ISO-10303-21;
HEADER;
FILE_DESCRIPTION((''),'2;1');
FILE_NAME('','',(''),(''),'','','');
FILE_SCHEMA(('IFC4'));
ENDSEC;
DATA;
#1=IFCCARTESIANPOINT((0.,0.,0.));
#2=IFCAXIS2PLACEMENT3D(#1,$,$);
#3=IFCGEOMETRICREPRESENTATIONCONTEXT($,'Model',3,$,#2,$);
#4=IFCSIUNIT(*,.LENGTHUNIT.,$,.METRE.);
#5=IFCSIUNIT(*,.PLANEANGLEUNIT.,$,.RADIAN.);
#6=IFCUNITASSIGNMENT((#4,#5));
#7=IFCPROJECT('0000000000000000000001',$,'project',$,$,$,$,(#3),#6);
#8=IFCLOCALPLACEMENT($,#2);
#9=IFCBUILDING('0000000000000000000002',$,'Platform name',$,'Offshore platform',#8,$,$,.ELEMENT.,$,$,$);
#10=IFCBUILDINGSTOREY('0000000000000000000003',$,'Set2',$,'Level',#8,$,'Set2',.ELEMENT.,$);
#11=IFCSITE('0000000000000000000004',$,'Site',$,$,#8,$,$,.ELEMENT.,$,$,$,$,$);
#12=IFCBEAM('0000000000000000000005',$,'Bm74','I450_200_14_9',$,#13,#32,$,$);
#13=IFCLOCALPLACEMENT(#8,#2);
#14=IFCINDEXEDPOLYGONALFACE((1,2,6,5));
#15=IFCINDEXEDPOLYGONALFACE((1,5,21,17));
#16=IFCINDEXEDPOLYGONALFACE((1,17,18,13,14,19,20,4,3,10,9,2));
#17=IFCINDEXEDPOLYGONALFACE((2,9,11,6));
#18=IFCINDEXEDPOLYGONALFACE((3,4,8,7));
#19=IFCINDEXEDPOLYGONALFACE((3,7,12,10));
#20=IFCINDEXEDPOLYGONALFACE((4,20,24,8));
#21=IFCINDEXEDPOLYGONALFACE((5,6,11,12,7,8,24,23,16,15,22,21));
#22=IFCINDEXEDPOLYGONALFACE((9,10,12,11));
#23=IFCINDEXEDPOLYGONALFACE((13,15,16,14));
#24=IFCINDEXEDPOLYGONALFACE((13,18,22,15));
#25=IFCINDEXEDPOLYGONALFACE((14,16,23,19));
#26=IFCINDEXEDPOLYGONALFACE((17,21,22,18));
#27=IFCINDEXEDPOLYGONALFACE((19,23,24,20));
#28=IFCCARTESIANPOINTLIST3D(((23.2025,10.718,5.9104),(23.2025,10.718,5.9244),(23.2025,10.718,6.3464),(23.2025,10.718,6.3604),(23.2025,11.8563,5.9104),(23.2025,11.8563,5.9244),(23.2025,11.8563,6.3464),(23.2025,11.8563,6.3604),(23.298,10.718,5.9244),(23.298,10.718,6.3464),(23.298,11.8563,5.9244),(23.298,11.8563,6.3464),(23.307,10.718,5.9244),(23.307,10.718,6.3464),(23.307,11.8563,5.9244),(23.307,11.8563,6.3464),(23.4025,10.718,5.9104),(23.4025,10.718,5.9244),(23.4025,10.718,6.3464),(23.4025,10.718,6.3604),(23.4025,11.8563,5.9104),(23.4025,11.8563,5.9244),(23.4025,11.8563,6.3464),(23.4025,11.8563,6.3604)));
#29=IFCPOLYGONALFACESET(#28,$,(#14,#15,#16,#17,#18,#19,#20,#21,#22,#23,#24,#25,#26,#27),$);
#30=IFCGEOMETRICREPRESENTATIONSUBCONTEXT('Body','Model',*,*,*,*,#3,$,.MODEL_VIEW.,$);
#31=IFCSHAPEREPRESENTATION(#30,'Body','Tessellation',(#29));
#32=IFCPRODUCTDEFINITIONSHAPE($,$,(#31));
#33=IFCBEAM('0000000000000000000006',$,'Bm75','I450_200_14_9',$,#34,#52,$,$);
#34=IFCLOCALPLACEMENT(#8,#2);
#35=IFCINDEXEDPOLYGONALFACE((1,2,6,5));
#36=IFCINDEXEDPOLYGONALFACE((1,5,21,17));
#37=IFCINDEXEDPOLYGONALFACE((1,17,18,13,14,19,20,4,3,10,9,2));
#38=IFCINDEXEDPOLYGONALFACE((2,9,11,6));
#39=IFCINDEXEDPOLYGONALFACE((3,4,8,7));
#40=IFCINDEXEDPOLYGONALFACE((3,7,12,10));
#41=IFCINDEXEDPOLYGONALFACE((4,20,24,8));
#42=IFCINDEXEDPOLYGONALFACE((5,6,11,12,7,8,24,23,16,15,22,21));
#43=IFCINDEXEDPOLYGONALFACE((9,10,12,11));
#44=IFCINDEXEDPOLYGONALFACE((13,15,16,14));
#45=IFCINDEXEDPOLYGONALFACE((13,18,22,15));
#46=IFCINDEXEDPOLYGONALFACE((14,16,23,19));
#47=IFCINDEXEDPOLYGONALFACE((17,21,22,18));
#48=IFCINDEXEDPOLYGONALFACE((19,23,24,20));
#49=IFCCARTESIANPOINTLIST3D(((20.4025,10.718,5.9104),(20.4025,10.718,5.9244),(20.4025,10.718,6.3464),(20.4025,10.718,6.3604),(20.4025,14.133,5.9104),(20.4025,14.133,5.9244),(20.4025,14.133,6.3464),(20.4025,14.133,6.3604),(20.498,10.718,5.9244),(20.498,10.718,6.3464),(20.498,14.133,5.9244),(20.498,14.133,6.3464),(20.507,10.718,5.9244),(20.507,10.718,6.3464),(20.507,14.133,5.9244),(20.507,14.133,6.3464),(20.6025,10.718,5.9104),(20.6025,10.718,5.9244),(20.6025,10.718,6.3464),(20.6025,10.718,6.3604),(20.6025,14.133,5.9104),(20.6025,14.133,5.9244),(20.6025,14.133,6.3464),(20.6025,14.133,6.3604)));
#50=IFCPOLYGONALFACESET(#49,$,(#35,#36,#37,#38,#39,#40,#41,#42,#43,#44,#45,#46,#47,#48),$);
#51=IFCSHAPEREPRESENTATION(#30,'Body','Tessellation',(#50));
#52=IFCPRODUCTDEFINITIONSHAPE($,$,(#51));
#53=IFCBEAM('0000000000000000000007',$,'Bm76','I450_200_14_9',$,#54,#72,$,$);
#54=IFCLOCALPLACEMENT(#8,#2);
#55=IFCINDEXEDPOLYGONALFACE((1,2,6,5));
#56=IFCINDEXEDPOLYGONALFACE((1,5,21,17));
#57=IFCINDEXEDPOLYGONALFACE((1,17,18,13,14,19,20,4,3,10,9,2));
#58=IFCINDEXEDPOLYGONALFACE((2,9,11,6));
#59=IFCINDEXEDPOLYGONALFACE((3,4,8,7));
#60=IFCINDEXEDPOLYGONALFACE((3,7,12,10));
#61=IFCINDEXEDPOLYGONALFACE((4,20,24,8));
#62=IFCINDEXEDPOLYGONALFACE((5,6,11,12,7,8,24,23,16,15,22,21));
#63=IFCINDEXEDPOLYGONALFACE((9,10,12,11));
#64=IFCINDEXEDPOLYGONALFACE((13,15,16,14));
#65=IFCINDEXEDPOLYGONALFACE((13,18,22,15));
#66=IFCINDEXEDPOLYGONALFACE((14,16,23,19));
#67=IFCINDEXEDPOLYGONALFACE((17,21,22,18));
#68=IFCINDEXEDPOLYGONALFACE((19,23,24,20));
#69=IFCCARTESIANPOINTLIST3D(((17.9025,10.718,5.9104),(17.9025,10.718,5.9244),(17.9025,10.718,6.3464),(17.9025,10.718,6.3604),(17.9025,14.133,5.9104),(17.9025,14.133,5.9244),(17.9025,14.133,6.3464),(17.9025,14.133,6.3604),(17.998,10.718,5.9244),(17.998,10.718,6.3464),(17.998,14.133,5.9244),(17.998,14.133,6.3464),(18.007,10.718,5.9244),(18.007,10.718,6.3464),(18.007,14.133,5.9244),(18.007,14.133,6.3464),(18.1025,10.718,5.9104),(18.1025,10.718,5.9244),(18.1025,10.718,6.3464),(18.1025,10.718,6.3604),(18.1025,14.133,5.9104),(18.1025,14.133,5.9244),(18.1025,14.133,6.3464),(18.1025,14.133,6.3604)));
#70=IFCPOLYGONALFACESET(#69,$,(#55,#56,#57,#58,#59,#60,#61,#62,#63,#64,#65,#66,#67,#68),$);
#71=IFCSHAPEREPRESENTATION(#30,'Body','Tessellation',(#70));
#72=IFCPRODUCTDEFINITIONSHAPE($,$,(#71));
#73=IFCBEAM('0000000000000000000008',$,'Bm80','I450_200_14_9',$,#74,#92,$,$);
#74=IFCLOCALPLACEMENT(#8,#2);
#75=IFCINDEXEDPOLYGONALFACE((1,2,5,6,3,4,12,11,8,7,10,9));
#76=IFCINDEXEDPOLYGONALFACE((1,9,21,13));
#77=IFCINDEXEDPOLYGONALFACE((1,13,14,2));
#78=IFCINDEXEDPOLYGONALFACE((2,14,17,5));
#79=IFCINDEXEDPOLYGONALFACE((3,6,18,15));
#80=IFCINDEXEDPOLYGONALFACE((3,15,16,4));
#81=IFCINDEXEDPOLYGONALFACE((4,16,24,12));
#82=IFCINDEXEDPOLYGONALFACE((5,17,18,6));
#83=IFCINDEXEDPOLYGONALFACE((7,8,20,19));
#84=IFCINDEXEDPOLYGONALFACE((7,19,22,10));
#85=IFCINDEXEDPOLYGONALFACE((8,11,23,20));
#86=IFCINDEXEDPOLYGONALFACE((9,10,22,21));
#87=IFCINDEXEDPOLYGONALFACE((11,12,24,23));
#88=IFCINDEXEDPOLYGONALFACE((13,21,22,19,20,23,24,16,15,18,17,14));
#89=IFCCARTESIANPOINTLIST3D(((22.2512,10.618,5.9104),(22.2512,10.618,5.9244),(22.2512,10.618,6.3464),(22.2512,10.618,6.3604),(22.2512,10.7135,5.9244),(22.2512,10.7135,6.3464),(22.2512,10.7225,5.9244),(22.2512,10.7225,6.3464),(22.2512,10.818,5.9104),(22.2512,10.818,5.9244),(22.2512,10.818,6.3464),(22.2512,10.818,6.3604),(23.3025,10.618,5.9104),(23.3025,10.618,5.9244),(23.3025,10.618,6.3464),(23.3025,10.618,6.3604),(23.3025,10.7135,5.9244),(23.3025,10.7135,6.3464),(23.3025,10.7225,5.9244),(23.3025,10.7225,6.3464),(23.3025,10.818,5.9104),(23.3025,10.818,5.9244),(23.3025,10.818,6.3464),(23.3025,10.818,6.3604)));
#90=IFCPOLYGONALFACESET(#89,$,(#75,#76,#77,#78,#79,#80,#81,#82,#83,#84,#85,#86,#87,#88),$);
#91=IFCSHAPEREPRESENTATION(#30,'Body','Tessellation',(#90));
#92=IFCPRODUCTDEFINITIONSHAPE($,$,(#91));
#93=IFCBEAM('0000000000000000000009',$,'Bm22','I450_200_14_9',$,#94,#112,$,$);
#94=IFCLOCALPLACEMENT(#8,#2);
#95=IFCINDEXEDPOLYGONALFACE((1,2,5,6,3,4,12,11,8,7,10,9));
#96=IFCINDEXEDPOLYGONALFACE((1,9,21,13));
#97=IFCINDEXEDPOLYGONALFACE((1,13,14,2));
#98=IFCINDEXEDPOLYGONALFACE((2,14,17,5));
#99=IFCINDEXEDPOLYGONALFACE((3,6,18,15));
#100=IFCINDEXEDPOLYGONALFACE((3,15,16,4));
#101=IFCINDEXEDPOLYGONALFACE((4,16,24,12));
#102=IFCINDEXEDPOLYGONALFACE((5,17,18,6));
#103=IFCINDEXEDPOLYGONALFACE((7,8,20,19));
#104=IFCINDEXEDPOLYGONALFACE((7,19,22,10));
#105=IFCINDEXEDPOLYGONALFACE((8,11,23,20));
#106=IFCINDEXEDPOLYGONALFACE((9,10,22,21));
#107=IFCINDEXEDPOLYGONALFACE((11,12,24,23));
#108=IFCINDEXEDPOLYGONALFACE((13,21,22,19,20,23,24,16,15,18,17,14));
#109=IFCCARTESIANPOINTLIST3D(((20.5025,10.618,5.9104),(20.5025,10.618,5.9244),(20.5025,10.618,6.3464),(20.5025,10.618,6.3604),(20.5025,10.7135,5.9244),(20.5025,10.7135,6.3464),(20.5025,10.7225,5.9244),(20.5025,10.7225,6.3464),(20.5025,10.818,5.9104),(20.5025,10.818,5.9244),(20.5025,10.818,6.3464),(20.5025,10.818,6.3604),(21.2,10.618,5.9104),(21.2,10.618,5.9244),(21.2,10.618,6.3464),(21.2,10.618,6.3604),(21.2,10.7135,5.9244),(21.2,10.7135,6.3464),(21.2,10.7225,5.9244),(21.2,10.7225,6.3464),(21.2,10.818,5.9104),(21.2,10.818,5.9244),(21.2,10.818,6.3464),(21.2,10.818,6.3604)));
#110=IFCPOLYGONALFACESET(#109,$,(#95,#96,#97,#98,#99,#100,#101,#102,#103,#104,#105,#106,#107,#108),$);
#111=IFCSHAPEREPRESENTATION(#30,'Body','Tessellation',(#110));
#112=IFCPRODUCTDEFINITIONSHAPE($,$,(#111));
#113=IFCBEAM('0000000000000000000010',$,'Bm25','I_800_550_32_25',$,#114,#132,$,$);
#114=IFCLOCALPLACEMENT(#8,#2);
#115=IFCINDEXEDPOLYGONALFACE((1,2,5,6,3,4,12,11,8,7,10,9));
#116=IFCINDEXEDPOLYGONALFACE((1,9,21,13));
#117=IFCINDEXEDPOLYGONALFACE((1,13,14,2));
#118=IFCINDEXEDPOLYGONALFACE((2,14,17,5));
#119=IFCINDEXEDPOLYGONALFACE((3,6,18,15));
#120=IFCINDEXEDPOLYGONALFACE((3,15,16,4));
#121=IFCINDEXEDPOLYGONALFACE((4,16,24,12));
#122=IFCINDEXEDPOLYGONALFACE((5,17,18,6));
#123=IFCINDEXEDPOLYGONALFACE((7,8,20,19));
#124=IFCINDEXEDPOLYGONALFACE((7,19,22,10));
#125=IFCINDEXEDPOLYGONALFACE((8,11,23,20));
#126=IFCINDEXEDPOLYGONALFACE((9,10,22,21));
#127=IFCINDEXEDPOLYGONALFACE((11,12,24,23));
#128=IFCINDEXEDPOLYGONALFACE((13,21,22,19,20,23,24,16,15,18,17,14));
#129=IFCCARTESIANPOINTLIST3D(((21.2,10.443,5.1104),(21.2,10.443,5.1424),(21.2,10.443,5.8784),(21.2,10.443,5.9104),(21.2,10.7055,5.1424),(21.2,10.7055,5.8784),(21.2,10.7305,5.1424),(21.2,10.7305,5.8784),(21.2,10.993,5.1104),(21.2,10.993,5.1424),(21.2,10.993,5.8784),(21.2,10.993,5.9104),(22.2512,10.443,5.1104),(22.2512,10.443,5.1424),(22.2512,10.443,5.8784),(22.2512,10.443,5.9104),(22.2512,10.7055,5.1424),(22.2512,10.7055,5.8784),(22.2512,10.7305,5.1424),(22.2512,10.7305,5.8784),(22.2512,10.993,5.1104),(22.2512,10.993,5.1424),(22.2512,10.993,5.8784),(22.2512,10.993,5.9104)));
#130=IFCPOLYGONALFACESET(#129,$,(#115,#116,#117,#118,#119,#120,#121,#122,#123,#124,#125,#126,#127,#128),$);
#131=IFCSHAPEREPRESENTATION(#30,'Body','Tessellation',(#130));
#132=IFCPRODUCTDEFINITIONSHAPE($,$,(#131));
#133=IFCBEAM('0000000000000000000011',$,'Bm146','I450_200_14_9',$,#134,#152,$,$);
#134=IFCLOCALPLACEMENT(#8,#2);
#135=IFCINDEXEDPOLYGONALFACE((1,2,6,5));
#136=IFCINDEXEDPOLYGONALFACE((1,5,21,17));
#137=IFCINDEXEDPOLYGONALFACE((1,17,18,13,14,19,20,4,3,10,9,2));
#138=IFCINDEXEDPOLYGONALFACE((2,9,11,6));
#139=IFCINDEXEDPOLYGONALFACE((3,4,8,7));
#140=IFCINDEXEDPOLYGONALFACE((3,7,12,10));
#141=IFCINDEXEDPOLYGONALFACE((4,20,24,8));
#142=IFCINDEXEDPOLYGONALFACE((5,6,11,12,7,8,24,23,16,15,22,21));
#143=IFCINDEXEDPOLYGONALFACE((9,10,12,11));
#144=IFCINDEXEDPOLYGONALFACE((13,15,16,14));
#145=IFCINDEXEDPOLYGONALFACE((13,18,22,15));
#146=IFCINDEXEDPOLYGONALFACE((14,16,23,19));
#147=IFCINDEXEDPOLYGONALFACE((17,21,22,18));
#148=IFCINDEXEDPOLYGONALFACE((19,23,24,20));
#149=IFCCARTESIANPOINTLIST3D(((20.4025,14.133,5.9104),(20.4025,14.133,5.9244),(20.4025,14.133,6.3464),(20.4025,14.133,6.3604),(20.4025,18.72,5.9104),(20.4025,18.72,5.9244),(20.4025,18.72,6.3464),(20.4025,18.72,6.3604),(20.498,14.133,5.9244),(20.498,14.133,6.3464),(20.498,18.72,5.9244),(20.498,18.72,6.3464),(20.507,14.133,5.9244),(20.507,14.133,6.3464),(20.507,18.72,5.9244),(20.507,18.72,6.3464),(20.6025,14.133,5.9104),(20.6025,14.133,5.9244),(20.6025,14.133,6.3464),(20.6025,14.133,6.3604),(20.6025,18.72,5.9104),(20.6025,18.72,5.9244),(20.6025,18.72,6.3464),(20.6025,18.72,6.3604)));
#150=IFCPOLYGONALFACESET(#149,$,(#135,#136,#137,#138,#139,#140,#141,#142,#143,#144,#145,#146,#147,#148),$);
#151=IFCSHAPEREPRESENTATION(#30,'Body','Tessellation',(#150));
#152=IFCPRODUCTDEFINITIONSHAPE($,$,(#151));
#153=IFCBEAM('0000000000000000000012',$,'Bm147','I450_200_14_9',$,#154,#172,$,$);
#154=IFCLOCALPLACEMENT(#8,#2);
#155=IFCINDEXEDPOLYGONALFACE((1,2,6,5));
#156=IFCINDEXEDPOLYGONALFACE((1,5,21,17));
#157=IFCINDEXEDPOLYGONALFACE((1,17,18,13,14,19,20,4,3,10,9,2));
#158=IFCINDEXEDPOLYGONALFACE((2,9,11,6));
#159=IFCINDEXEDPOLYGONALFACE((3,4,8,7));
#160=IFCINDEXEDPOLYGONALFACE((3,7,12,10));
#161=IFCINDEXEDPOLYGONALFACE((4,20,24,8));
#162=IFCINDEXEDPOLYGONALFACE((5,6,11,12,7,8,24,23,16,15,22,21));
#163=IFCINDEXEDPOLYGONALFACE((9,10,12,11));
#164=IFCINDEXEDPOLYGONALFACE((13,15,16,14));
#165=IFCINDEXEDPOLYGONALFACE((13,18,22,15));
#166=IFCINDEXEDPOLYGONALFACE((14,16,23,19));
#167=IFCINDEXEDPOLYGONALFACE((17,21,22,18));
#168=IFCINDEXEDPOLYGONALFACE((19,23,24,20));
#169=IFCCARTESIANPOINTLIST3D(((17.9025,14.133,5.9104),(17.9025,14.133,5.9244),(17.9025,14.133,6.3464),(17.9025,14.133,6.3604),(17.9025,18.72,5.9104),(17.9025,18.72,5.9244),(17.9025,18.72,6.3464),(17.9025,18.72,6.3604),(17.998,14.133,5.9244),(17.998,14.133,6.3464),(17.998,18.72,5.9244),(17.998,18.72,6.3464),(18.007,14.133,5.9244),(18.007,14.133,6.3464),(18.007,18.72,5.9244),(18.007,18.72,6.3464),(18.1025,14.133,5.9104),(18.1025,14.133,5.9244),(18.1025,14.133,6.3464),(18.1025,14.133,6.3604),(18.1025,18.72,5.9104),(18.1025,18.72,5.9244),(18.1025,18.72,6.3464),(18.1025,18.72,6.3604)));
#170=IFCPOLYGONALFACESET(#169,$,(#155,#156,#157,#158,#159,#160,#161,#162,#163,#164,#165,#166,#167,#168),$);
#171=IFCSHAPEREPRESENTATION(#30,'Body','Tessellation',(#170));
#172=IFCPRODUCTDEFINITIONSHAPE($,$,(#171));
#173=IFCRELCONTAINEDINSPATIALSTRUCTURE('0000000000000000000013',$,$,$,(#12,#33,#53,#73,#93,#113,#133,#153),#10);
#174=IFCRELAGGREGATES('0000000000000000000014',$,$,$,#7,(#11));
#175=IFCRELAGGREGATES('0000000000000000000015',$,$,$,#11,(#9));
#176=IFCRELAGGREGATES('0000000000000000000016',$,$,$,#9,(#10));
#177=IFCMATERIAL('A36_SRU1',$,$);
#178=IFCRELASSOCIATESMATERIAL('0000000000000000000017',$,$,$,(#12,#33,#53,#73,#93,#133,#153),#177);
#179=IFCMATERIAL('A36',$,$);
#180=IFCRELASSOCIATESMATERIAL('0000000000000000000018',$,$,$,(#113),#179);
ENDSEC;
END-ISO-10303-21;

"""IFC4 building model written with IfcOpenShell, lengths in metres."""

from ifc_helpers import new_model, si_unit, frame, origin, origin_2d, place, context, subcontext, project, spatial, i_section, extrude, source, transform, mapped, material, element, save


model = new_model("IFC4")

# Units and contexts
model_context = context("Model", 3, world=origin())
body_context = subcontext(model_context, "Body", "Model", "MODEL_VIEW")
ifc_project = project(units=[si_unit("LENGTHUNIT", "METRE"), si_unit("PLANEANGLEUNIT", "RADIAN")], contexts=[model_context])

# Site, building, storey
placement_1 = place(None, origin())
site = spatial("IfcSite", under=ifc_project, at=placement_1, Name="Site", CompositionType="ELEMENT")
building = spatial("IfcBuilding", under=site, at=placement_1, Name="Platform name", ObjectType="Offshore platform", CompositionType="ELEMENT")
storey = spatial("IfcBuildingStorey", under=building, at=placement_1, Name="Set2", ObjectType="Level", LongName="Set2", CompositionType="ELEMENT")

# Beams
ifc_material_1 = material(Name="A36_SRU1")
shared_shape_1 = source(origin(), body_context, "Body", "SweptSolid", [
    extrude(i_section(OverallWidth=0.2, OverallDepth=0.45, WebThickness=0.009, FlangeThickness=0.014, FilletRadius=0.0, at=origin_2d()), frame((0.0, 0.0, 0.0), z_axis=(0.0, 1.0, 0.0), x_axis=(-1.0, 0.0, 0.0)), (0.0, 0.0, 1.0), 1.1383),
])
placement_2 = place(None, origin())
placement_3 = place(placement_2, origin())
placement_4 = place(placement_3, origin())
beam_1_placement = place(placement_4, frame((23.3025, 10.718, 6.1354)))
element("IfcBeam", 1, at=beam_1_placement, inside=storey, material=ifc_material_1, Name="Bm74", Description="I450_200_14_9", context=body_context, shape_type="MappedRepresentation", body=[
    mapped(shared_shape_1, transform((0.0, 0.0, 0.0), scale=1.0)),
])
shared_shape_2 = source(origin(), body_context, "Body", "SweptSolid", [
    extrude(i_section(OverallWidth=0.2, OverallDepth=0.45, WebThickness=0.009, FlangeThickness=0.014, FilletRadius=0.0, at=origin_2d()), frame((0.0, 0.0, 0.0), z_axis=(0.0, 1.0, 0.0), x_axis=(-1.0, 0.0, 0.0)), (0.0, 0.0, 1.0), 3.415),
])
placement_5 = place(None, origin())
placement_6 = place(placement_5, origin())
placement_7 = place(placement_6, origin())
beam_2_placement = place(placement_7, frame((20.5025, 10.718, 6.1354)))
element("IfcBeam", 2, at=beam_2_placement, inside=storey, material=ifc_material_1, Name="Bm75", Description="I450_200_14_9", context=body_context, shape_type="MappedRepresentation", body=[
    mapped(shared_shape_2, transform((0.0, 0.0, 0.0), scale=1.0)),
])
shared_shape_3 = source(origin(), body_context, "Body", "SweptSolid", [
    extrude(i_section(OverallWidth=0.2, OverallDepth=0.45, WebThickness=0.009, FlangeThickness=0.014, FilletRadius=0.0, at=origin_2d()), frame((0.0, 0.0, 0.0), z_axis=(0.0, 1.0, 0.0), x_axis=(-1.0, 0.0, 0.0)), (0.0, 0.0, 1.0), 3.415),
])
placement_8 = place(None, origin())
placement_9 = place(placement_8, origin())
placement_10 = place(placement_9, origin())
beam_3_placement = place(placement_10, frame((18.0025, 10.718, 6.1354)))
element("IfcBeam", 3, at=beam_3_placement, inside=storey, material=ifc_material_1, Name="Bm76", Description="I450_200_14_9", context=body_context, shape_type="MappedRepresentation", body=[
    mapped(shared_shape_3, transform((0.0, 0.0, 0.0), scale=1.0)),
])
shared_shape_4 = source(origin(), body_context, "Body", "SweptSolid", [
    extrude(i_section(OverallWidth=0.2, OverallDepth=0.45, WebThickness=0.009, FlangeThickness=0.014, FilletRadius=0.0, at=origin_2d()), frame((0.0, 0.0, 0.0), z_axis=(-1.0, 0.0, 0.0), x_axis=(0.0, -1.0, 0.0)), (0.0, 0.0, 1.0), 1.0513),
])
placement_11 = place(None, origin())
placement_12 = place(placement_11, origin())
placement_13 = place(placement_12, origin())
beam_4_placement = place(placement_13, frame((23.3025, 10.718, 6.1354)))
element("IfcBeam", 4, at=beam_4_placement, inside=storey, material=ifc_material_1, Name="Bm80", Description="I450_200_14_9", context=body_context, shape_type="MappedRepresentation", body=[
    mapped(shared_shape_4, transform((0.0, 0.0, 0.0), scale=1.0)),
])
shared_shape_5 = source(origin(), body_context, "Body", "SweptSolid", [
    extrude(i_section(OverallWidth=0.2, OverallDepth=0.45, WebThickness=0.009, FlangeThickness=0.014, FilletRadius=0.0, at=origin_2d()), frame((0.0, 0.0, 0.0), z_axis=(-1.0, 0.0, 0.0), x_axis=(0.0, -1.0, 0.0)), (0.0, 0.0, 1.0), 0.6975),
])
placement_14 = place(None, origin())
placement_15 = place(placement_14, origin())
placement_16 = place(placement_15, origin())
beam_5_placement = place(placement_16, frame((21.2, 10.718, 6.1354)))
element("IfcBeam", 5, at=beam_5_placement, inside=storey, material=ifc_material_1, Name="Bm22", Description="I450_200_14_9", context=body_context, shape_type="MappedRepresentation", body=[
    mapped(shared_shape_5, transform((0.0, 0.0, 0.0), scale=1.0)),
])
ifc_material_2 = material(Name="A36")
shared_shape_6 = source(origin(), body_context, "Body", "SweptSolid", [
    extrude(i_section(OverallWidth=0.55, OverallDepth=0.8, WebThickness=0.025, FlangeThickness=0.032, FilletRadius=0.0, at=origin_2d()), frame((0.0, 0.0, 0.0), z_axis=(1.0, 0.0, 0.0), x_axis=(0.0, 1.0, 0.0)), (0.0, 0.0, 1.0), 1.0513),
])
placement_17 = place(None, origin())
placement_18 = place(placement_17, origin())
placement_19 = place(placement_18, origin())
beam_6_placement = place(placement_19, frame((21.2, 10.718, 5.5104)))
element("IfcBeam", 6, at=beam_6_placement, inside=storey, material=ifc_material_2, Name="Bm25", Description="I_800_550_32_25", context=body_context, shape_type="MappedRepresentation", body=[
    mapped(shared_shape_6, transform((0.0, 0.0, 0.0), scale=1.0)),
])
shared_shape_7 = source(origin(), body_context, "Body", "SweptSolid", [
    extrude(i_section(OverallWidth=0.2, OverallDepth=0.45, WebThickness=0.009, FlangeThickness=0.014, FilletRadius=0.0, at=origin_2d()), frame((0.0, 0.0, 0.0), z_axis=(0.0, 1.0, 0.0), x_axis=(-1.0, 0.0, 0.0)), (0.0, 0.0, 1.0), 4.587),
])
placement_20 = place(None, origin())
placement_21 = place(placement_20, origin())
placement_22 = place(placement_21, origin())
beam_7_placement = place(placement_22, frame((20.5025, 14.133, 6.1354)))
element("IfcBeam", 7, at=beam_7_placement, inside=storey, material=ifc_material_1, Name="Bm146", Description="I450_200_14_9", context=body_context, shape_type="MappedRepresentation", body=[
    mapped(shared_shape_7, transform((0.0, 0.0, 0.0), scale=1.0)),
])
shared_shape_8 = source(origin(), body_context, "Body", "SweptSolid", [
    extrude(i_section(OverallWidth=0.2, OverallDepth=0.45, WebThickness=0.009, FlangeThickness=0.014, FilletRadius=0.0, at=origin_2d()), frame((0.0, 0.0, 0.0), z_axis=(0.0, 1.0, 0.0), x_axis=(-1.0, 0.0, 0.0)), (0.0, 0.0, 1.0), 4.587),
])
placement_23 = place(None, origin())
placement_24 = place(placement_23, origin())
placement_25 = place(placement_24, origin())
beam_8_placement = place(placement_25, frame((18.0025, 14.133, 6.1354)))
element("IfcBeam", 8, at=beam_8_placement, inside=storey, material=ifc_material_1, Name="Bm147", Description="I450_200_14_9", context=body_context, shape_type="MappedRepresentation", body=[
    mapped(shared_shape_8, transform((0.0, 0.0, 0.0), scale=1.0)),
])

save(model, "model.ifc")
